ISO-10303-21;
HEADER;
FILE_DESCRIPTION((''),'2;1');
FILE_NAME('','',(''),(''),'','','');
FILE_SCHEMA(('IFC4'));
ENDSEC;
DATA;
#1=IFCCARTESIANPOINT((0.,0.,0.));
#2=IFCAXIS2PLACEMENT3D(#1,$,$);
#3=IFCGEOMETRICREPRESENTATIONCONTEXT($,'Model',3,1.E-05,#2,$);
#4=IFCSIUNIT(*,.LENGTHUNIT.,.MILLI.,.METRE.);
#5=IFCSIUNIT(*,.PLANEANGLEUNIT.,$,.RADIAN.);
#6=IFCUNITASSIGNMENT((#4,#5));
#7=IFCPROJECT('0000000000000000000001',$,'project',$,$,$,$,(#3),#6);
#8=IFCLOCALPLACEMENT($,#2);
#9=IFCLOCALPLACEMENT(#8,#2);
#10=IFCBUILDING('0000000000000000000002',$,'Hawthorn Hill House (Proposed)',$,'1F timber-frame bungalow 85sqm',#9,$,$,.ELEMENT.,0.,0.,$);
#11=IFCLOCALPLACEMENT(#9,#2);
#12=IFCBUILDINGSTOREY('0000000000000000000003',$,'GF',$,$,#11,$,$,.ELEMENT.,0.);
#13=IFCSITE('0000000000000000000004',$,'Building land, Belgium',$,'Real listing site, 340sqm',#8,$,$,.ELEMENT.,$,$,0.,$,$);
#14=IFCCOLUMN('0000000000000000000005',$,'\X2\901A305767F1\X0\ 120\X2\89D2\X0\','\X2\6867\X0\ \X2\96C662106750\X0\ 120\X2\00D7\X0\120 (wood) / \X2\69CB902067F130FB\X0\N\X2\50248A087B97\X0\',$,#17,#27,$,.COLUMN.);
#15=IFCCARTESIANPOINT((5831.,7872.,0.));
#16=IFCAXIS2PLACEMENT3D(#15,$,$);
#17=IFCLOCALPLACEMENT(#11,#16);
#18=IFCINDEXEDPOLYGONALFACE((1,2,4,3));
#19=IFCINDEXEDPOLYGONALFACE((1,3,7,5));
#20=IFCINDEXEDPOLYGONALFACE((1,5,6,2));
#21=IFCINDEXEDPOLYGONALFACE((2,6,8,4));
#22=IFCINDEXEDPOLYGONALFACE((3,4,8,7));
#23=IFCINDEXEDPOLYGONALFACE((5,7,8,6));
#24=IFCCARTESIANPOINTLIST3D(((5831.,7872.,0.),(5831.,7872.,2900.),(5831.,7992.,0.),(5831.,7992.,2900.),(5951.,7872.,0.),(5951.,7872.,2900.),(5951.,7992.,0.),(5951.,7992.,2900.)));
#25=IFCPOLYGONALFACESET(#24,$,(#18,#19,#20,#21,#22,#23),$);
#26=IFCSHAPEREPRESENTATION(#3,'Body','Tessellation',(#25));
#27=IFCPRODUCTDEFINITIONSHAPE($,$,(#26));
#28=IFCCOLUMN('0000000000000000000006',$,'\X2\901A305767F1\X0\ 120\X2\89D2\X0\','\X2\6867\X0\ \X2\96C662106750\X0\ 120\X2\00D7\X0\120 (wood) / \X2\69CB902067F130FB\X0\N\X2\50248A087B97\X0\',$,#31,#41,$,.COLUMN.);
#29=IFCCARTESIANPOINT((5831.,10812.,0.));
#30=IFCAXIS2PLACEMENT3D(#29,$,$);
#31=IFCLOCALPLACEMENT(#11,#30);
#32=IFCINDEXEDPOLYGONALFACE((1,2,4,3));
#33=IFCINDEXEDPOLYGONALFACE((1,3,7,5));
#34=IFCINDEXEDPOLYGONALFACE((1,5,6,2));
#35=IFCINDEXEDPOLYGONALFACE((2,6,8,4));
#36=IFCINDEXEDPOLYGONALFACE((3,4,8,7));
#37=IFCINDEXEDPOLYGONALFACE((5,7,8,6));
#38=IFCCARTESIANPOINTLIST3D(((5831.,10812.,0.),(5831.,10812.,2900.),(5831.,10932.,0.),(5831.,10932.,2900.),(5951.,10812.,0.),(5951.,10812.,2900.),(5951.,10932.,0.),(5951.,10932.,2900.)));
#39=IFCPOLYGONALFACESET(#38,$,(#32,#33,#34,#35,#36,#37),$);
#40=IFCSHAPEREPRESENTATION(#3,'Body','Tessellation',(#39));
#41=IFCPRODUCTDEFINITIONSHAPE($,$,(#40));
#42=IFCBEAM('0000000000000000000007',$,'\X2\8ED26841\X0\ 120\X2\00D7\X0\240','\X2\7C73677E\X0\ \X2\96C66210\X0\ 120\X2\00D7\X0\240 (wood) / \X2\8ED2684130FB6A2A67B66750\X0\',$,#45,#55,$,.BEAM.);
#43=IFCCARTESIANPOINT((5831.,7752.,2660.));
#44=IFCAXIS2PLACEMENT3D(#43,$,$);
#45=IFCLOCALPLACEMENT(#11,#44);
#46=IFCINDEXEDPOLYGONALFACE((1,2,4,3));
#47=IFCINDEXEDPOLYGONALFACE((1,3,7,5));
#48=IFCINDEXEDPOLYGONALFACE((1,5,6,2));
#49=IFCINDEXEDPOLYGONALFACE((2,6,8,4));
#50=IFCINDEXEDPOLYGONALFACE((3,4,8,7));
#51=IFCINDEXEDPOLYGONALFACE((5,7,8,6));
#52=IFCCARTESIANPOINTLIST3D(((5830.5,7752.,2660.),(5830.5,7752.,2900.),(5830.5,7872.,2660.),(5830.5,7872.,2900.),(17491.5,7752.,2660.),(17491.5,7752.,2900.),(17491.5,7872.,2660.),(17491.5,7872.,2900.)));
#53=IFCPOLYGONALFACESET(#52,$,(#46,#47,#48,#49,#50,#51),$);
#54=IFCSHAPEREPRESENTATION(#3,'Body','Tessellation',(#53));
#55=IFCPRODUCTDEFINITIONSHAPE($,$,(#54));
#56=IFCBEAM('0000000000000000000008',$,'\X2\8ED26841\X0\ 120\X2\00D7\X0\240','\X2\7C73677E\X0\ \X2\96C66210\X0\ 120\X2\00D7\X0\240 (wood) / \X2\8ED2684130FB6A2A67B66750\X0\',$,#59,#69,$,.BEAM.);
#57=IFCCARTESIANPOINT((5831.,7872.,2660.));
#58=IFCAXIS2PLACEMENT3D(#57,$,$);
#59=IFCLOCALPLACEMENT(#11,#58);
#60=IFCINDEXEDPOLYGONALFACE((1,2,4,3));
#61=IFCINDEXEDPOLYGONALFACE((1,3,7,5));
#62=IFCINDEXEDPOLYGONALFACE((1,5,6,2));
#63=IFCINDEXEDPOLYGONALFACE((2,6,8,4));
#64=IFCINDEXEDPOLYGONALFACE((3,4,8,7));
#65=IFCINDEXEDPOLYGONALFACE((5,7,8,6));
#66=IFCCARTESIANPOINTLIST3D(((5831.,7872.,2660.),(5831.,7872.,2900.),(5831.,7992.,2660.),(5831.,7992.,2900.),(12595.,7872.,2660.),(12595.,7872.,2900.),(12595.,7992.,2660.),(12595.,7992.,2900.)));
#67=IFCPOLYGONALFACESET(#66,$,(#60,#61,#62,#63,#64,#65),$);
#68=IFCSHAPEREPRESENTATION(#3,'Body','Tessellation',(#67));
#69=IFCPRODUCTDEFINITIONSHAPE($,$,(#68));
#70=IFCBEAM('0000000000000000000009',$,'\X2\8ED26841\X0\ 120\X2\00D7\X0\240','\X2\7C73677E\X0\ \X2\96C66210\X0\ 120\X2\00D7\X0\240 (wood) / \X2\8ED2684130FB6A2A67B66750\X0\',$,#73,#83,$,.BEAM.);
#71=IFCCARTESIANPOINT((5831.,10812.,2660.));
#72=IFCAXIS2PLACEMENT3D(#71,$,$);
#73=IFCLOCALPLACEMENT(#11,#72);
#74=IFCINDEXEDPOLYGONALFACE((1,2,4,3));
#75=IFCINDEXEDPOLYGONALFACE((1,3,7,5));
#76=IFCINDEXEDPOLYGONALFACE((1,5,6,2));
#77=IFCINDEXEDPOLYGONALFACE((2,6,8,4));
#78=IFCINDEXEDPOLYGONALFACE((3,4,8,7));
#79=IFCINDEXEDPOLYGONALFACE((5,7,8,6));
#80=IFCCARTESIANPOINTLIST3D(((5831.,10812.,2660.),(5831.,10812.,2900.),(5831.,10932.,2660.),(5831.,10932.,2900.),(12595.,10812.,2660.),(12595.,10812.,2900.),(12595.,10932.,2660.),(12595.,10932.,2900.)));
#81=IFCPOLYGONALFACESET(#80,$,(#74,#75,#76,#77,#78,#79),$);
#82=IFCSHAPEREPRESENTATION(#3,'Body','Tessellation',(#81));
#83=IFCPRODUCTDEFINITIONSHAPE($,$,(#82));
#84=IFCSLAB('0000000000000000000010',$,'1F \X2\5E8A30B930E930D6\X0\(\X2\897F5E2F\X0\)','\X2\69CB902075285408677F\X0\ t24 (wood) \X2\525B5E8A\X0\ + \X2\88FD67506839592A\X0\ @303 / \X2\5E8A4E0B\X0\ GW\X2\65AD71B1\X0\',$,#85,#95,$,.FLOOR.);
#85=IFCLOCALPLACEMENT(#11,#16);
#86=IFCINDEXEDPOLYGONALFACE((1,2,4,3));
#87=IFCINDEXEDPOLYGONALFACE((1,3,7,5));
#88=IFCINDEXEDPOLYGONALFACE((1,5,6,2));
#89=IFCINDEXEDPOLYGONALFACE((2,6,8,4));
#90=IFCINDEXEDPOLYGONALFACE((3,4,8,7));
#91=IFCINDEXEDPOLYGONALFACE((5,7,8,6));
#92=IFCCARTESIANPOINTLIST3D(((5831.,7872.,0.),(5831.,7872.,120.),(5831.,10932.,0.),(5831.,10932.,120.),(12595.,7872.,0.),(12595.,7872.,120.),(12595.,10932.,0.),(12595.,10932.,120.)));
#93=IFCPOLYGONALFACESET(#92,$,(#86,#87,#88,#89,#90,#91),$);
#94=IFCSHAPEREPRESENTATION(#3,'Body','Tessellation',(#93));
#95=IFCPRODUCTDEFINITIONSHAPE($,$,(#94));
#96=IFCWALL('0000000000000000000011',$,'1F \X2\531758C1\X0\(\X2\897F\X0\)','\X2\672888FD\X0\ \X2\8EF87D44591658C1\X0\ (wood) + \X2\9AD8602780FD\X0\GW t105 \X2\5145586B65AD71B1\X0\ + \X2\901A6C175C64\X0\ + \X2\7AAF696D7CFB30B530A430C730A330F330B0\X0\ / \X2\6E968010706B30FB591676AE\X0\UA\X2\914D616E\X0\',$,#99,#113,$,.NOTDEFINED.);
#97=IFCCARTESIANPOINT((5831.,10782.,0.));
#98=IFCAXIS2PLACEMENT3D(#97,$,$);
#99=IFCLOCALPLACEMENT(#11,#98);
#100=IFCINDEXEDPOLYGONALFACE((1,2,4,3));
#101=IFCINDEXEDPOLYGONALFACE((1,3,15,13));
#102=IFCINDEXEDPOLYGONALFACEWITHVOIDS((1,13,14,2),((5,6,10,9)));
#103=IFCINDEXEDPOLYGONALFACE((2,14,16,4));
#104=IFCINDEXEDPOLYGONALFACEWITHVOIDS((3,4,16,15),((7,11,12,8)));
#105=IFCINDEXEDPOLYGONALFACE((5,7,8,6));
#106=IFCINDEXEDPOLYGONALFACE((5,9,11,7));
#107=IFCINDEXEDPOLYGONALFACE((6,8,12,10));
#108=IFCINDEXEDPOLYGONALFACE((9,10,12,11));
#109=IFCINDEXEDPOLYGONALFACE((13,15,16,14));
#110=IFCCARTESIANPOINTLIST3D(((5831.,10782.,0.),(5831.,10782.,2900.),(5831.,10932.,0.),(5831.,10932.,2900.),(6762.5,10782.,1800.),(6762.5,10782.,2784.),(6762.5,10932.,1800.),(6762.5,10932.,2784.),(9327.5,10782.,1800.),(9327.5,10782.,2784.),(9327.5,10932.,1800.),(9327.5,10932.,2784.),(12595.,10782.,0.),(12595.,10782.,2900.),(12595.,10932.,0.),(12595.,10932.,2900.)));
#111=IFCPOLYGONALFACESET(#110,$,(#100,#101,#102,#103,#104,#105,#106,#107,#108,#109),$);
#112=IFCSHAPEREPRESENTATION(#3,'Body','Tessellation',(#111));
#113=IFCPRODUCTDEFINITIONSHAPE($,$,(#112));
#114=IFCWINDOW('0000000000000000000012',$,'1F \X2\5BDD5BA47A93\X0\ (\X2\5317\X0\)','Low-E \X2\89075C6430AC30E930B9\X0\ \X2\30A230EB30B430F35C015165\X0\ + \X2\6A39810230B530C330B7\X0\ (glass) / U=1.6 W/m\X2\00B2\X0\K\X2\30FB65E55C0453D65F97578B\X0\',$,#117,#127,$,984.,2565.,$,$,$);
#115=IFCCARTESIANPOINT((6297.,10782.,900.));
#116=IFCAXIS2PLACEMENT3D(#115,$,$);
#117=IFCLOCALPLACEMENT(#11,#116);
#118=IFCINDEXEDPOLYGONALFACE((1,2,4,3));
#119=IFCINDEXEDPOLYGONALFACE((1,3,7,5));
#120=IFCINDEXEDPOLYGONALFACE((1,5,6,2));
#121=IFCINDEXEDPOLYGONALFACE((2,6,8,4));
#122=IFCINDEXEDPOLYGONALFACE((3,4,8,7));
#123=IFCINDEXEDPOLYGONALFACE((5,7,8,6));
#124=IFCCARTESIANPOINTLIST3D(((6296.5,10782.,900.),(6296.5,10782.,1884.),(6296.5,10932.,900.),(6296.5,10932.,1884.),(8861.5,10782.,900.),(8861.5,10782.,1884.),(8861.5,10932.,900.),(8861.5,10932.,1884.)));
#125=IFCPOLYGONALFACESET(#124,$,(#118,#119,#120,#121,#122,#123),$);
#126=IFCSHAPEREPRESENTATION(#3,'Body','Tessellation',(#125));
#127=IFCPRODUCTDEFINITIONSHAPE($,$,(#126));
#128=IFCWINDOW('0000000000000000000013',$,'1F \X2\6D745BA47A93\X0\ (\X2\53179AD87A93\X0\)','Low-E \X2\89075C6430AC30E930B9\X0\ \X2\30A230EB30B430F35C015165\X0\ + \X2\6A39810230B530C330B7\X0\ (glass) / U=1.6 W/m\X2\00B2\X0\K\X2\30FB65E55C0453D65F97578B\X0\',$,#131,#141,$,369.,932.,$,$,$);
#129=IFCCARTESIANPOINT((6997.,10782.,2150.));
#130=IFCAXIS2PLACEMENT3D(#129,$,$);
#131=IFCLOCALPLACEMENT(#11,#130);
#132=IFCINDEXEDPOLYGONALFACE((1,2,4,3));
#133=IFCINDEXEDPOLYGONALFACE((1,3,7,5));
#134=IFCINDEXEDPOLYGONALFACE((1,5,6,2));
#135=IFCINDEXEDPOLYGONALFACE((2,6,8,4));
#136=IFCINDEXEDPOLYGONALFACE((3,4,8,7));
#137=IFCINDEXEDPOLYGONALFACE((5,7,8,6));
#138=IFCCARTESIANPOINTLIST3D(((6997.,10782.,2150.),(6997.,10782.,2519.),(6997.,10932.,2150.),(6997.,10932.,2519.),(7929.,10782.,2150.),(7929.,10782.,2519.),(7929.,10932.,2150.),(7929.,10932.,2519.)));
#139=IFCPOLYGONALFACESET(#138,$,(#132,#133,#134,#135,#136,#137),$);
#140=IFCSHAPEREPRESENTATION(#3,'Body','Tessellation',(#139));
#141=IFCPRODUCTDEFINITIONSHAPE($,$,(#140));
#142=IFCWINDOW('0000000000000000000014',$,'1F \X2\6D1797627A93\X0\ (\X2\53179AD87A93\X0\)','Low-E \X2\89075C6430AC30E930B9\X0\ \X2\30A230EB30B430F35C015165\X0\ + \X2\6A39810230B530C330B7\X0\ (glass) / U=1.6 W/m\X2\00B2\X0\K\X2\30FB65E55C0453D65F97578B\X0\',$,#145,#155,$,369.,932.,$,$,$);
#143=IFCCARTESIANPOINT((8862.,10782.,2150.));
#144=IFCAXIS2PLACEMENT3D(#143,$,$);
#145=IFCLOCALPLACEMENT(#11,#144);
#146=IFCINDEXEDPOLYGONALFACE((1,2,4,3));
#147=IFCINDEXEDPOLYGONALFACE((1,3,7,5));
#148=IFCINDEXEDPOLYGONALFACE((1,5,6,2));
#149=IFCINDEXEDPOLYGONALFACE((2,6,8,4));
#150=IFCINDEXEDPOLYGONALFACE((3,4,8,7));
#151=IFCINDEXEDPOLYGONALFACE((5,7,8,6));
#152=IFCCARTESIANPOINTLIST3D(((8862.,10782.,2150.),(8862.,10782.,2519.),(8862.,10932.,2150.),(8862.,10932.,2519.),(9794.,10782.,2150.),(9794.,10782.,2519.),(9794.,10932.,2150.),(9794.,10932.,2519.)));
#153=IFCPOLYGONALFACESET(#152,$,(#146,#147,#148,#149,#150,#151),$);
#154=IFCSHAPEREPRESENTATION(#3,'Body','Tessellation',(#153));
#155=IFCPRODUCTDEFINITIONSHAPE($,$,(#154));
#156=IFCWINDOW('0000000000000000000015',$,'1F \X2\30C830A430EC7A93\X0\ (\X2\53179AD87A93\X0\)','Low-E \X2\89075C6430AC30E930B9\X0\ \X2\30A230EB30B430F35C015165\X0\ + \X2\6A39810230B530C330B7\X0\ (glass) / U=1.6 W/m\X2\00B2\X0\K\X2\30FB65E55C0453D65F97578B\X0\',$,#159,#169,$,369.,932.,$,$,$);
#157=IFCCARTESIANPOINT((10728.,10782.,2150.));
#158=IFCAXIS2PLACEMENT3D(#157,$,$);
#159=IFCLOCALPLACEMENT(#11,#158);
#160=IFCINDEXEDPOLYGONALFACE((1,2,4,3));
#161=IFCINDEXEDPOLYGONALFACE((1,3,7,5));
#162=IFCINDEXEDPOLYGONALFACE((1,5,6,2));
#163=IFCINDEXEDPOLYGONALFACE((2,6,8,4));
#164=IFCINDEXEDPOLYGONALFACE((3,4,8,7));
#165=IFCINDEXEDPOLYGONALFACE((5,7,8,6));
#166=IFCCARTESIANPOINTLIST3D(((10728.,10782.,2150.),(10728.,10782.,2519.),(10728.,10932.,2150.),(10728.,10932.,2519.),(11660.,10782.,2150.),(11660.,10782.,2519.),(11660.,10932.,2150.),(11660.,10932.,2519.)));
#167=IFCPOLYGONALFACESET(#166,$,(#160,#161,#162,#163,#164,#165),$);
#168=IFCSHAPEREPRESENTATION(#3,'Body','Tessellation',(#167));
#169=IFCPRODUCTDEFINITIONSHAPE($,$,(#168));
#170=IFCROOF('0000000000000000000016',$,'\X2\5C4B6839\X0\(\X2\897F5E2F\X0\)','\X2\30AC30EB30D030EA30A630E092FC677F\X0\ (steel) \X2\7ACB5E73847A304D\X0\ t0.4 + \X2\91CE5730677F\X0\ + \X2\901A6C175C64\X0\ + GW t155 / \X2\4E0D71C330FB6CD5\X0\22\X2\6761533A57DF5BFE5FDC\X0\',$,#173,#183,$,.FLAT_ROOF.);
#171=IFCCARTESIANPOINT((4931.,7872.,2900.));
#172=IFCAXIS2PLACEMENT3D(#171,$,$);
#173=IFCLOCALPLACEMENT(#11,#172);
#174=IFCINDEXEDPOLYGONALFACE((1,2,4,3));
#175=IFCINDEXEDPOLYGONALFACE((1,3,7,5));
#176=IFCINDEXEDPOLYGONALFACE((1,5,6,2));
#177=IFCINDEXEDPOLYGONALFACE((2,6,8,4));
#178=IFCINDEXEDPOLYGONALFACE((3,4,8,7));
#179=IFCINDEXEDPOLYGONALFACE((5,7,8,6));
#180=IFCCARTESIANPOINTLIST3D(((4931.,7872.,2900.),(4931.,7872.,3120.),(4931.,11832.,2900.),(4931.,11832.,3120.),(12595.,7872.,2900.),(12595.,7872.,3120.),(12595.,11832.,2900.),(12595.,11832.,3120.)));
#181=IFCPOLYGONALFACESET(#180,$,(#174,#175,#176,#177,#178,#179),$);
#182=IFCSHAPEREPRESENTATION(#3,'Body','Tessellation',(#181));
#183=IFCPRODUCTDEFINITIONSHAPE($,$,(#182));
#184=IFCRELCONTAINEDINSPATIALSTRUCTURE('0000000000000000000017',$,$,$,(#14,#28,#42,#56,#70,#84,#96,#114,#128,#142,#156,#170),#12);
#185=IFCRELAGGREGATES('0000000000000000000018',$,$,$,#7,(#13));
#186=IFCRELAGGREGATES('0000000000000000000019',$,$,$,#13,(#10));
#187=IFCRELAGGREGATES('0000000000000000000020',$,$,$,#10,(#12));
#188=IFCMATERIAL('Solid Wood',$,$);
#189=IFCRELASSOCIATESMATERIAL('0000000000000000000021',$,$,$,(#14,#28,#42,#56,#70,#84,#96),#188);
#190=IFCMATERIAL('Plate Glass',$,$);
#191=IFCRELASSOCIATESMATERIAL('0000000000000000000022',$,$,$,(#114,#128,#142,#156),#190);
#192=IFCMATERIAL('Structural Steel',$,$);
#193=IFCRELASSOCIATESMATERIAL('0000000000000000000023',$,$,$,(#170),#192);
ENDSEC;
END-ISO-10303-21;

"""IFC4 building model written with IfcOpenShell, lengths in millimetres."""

from ifc_helpers import new_model, si_unit, frame, frame_2d, origin, place, context, project, spatial, rectangle, extrude, material, element, fill, save


model = new_model("IFC4")

# Units and contexts
model_context = context("Model", 3, precision=1e-05, world=origin())
ifc_project = project(units=[si_unit("LENGTHUNIT", "METRE", prefix="MILLI"), si_unit("PLANEANGLEUNIT", "RADIAN")], contexts=[model_context])

# Site, building, storey
site_placement = place(None, origin())
site = spatial("IfcSite", under=ifc_project, at=site_placement, Name="Building land, Belgium", ObjectType="Real listing site, 340sqm", CompositionType="ELEMENT", RefElevation=0.0)
building_placement = place(site_placement, origin())
building = spatial("IfcBuilding", under=site, at=building_placement, Name="Hawthorn Hill House (Proposed)", ObjectType="1F timber-frame bungalow 85sqm", CompositionType="ELEMENT", ElevationOfRefHeight=0.0, ElevationOfTerrain=0.0)
storey_placement = place(building_placement, origin())
storey = spatial("IfcBuildingStorey", under=building, at=storey_placement, Name="GF", CompositionType="ELEMENT", Elevation=0.0)

# Columns
ifc_material_1 = material(Name="Solid Wood")
column_1_placement = place(storey_placement, frame((5831.0, 7872.0, 0.0)))
element("IfcColumn", 1, at=column_1_placement, inside=storey, material=ifc_material_1, Name="通し柱 120角", Description="桧 集成材 120×120 (wood) / 構造柱・N値計算", PredefinedType="COLUMN", context=model_context, shape_type="SweptSolid", body=[
    extrude(rectangle(XDim=120.0, YDim=120.0, at=frame_2d((60.0, 60.0))), frame((5831.0, 7872.0, 0.0)), (0.0, 0.0, 1.0), 2900.0),
])
column_2_placement = place(storey_placement, frame((5831.0, 10812.0, 0.0)))
element("IfcColumn", 2, at=column_2_placement, inside=storey, material=ifc_material_1, Name="通し柱 120角", Description="桧 集成材 120×120 (wood) / 構造柱・N値計算", PredefinedType="COLUMN", context=model_context, shape_type="SweptSolid", body=[
    extrude(rectangle(XDim=120.0, YDim=120.0, at=frame_2d((60.0, 60.0))), frame((5831.0, 10812.0, 0.0)), (0.0, 0.0, 1.0), 2900.0),
])

# Beams
beam_1_placement = place(storey_placement, frame((5831.0, 7752.0, 2660.0)))
element("IfcBeam", 3, at=beam_1_placement, inside=storey, material=ifc_material_1, Name="軒桁 120×240", Description="米松 集成 120×240 (wood) / 軒桁・横架材", PredefinedType="BEAM", context=model_context, shape_type="SweptSolid", body=[
    extrude(rectangle(XDim=11661.0, YDim=120.0, at=frame_2d((5830.0, 60.0))), frame((5831.0, 7752.0, 2660.0)), (0.0, 0.0, 1.0), 240.0),
])
beam_2_placement = place(storey_placement, frame((5831.0, 7872.0, 2660.0)))
element("IfcBeam", 4, at=beam_2_placement, inside=storey, material=ifc_material_1, Name="軒桁 120×240", Description="米松 集成 120×240 (wood) / 軒桁・横架材", PredefinedType="BEAM", context=model_context, shape_type="SweptSolid", body=[
    extrude(rectangle(XDim=6764.0, YDim=120.0, at=frame_2d((3382.0, 60.0))), frame((5831.0, 7872.0, 2660.0)), (0.0, 0.0, 1.0), 240.0),
])
beam_3_placement = place(storey_placement, frame((5831.0, 10812.0, 2660.0)))
element("IfcBeam", 5, at=beam_3_placement, inside=storey, material=ifc_material_1, Name="軒桁 120×240", Description="米松 集成 120×240 (wood) / 軒桁・横架材", PredefinedType="BEAM", context=model_context, shape_type="SweptSolid", body=[
    extrude(rectangle(XDim=6764.0, YDim=120.0, at=frame_2d((3382.0, 60.0))), frame((5831.0, 10812.0, 2660.0)), (0.0, 0.0, 1.0), 240.0),
])

# Slab
slab_placement = place(storey_placement, frame((5831.0, 7872.0, 0.0)))
element("IfcSlab", 6, at=slab_placement, inside=storey, material=ifc_material_1, Name="1F 床スラブ(西帯)", Description="構造用合板 t24 (wood) 剛床 + 製材根太 @303 / 床下 GW断熱", PredefinedType="FLOOR", context=model_context, shape_type="SweptSolid", body=[
    extrude(rectangle(XDim=6764.0, YDim=3060.0, at=frame_2d((3382.0, 1530.0))), frame((5831.0, 7872.0, 0.0)), (0.0, 0.0, 1.0), 120.0),
])

# Wall, openings, windows
wall_1_placement = place(storey_placement, frame((5831.0, 10782.0, 0.0)))
wall_1 = element("IfcWall", 7, at=wall_1_placement, inside=storey, material=ifc_material_1, Name="1F 北壁(西)", Description="木製 軸組外壁 (wood) + 高性能GW t105 充填断熱 + 通気層 + 窯業系サイディング / 準耐火・外皮UA配慮", PredefinedType="NOTDEFINED", context=model_context, shape_type="SweptSolid", body=[
    extrude(rectangle(XDim=6764.0, YDim=150.0, at=frame_2d((3382.0, 75.0))), frame((5831.0, 10782.0, 0.0)), (0.0, 0.0, 1.0), 2900.0),
])
opening_1_placement = place(storey_placement, frame((6297.0, 10782.0, 900.0)))
opening_1 = element("IfcOpeningElement", 8, at=opening_1_placement, cuts=wall_1, PredefinedType="NOTDEFINED", context=model_context, shape_type="SweptSolid", body=[
    extrude(rectangle(XDim=2565.0, YDim=150.0, at=frame_2d((1282.0, 75.0))), frame((6297.0, 10782.0, 900.0)), (0.0, 0.0, 1.0), 984.0),
])
opening_2_placement = place(storey_placement, frame((6997.0, 10782.0, 2150.0)))
opening_2 = element("IfcOpeningElement", 9, at=opening_2_placement, cuts=wall_1, PredefinedType="NOTDEFINED", context=model_context, shape_type="SweptSolid", body=[
    extrude(rectangle(XDim=932.0, YDim=150.0, at=frame_2d((466.0, 75.0))), frame((6997.0, 10782.0, 2150.0)), (0.0, 0.0, 1.0), 369.0),
])
opening_3_placement = place(storey_placement, frame((8862.0, 10782.0, 2150.0)))
opening_3 = element("IfcOpeningElement", 10, at=opening_3_placement, cuts=wall_1, PredefinedType="NOTDEFINED", context=model_context, shape_type="SweptSolid", body=[
    extrude(rectangle(XDim=932.0, YDim=150.0, at=frame_2d((466.0, 75.0))), frame((8862.0, 10782.0, 2150.0)), (0.0, 0.0, 1.0), 369.0),
])
opening_4_placement = place(storey_placement, frame((10728.0, 10782.0, 2150.0)))
opening_4 = element("IfcOpeningElement", 11, at=opening_4_placement, cuts=wall_1, PredefinedType="NOTDEFINED", context=model_context, shape_type="SweptSolid", body=[
    extrude(rectangle(XDim=932.0, YDim=150.0, at=frame_2d((466.0, 75.0))), frame((10728.0, 10782.0, 2150.0)), (0.0, 0.0, 1.0), 369.0),
])
ifc_material_2 = material(Name="Plate Glass")
window_1_placement = place(storey_placement, frame((6297.0, 10782.0, 900.0)))
window_1 = element("IfcWindow", 12, at=window_1_placement, inside=storey, material=ifc_material_2, Name="1F 寝室窓 (北)", Description="Low-E 複層ガラス アルゴン封入 + 樹脂サッシ (glass) / U=1.6 W/m²K・日射取得型", OverallHeight=984.0, OverallWidth=2565.0, context=model_context, shape_type="SweptSolid", body=[
    extrude(rectangle(XDim=2565.0, YDim=150.0, at=frame_2d((1282.0, 75.0))), frame((6297.0, 10782.0, 900.0)), (0.0, 0.0, 1.0), 984.0),
])
fill(opening_1, window_1)
window_2_placement = place(storey_placement, frame((6997.0, 10782.0, 2150.0)))
window_2 = element("IfcWindow", 13, at=window_2_placement, inside=storey, material=ifc_material_2, Name="1F 浴室窓 (北高窓)", Description="Low-E 複層ガラス アルゴン封入 + 樹脂サッシ (glass) / U=1.6 W/m²K・日射取得型", OverallHeight=369.0, OverallWidth=932.0, context=model_context, shape_type="SweptSolid", body=[
    extrude(rectangle(XDim=932.0, YDim=150.0, at=frame_2d((466.0, 75.0))), frame((6997.0, 10782.0, 2150.0)), (0.0, 0.0, 1.0), 369.0),
])
fill(opening_2, window_2)
window_3_placement = place(storey_placement, frame((8862.0, 10782.0, 2150.0)))
window_3 = element("IfcWindow", 14, at=window_3_placement, inside=storey, material=ifc_material_2, Name="1F 洗面窓 (北高窓)", Description="Low-E 複層ガラス アルゴン封入 + 樹脂サッシ (glass) / U=1.6 W/m²K・日射取得型", OverallHeight=369.0, OverallWidth=932.0, context=model_context, shape_type="SweptSolid", body=[
    extrude(rectangle(XDim=932.0, YDim=150.0, at=frame_2d((466.0, 75.0))), frame((8862.0, 10782.0, 2150.0)), (0.0, 0.0, 1.0), 369.0),
])
fill(opening_3, window_3)
window_4_placement = place(storey_placement, frame((10728.0, 10782.0, 2150.0)))
window_4 = element("IfcWindow", 15, at=window_4_placement, inside=storey, material=ifc_material_2, Name="1F トイレ窓 (北高窓)", Description="Low-E 複層ガラス アルゴン封入 + 樹脂サッシ (glass) / U=1.6 W/m²K・日射取得型", OverallHeight=369.0, OverallWidth=932.0, context=model_context, shape_type="SweptSolid", body=[
    extrude(rectangle(XDim=932.0, YDim=150.0, at=frame_2d((466.0, 75.0))), frame((10728.0, 10782.0, 2150.0)), (0.0, 0.0, 1.0), 369.0),
])
fill(opening_4, window_4)

# Roof
ifc_material_3 = material(Name="Structural Steel")
roof_placement = place(storey_placement, frame((4931.0, 7872.0, 2900.0)))
element("IfcRoof", 16, at=roof_placement, inside=storey, material=ifc_material_3, Name="屋根(西帯)", Description="ガルバリウム鋼板 (steel) 立平葺き t0.4 + 野地板 + 通気層 + GW t155 / 不燃・法22条区域対応", PredefinedType="FLAT_ROOF", context=model_context, shape_type="SweptSolid", body=[
    extrude(rectangle(XDim=7664.0, YDim=3960.0, at=frame_2d((3832.0, 1980.0))), frame((4931.0, 7872.0, 2900.0)), (0.0, 0.0, 1.0), 220.0),
])

save(model, "model.ifc")
